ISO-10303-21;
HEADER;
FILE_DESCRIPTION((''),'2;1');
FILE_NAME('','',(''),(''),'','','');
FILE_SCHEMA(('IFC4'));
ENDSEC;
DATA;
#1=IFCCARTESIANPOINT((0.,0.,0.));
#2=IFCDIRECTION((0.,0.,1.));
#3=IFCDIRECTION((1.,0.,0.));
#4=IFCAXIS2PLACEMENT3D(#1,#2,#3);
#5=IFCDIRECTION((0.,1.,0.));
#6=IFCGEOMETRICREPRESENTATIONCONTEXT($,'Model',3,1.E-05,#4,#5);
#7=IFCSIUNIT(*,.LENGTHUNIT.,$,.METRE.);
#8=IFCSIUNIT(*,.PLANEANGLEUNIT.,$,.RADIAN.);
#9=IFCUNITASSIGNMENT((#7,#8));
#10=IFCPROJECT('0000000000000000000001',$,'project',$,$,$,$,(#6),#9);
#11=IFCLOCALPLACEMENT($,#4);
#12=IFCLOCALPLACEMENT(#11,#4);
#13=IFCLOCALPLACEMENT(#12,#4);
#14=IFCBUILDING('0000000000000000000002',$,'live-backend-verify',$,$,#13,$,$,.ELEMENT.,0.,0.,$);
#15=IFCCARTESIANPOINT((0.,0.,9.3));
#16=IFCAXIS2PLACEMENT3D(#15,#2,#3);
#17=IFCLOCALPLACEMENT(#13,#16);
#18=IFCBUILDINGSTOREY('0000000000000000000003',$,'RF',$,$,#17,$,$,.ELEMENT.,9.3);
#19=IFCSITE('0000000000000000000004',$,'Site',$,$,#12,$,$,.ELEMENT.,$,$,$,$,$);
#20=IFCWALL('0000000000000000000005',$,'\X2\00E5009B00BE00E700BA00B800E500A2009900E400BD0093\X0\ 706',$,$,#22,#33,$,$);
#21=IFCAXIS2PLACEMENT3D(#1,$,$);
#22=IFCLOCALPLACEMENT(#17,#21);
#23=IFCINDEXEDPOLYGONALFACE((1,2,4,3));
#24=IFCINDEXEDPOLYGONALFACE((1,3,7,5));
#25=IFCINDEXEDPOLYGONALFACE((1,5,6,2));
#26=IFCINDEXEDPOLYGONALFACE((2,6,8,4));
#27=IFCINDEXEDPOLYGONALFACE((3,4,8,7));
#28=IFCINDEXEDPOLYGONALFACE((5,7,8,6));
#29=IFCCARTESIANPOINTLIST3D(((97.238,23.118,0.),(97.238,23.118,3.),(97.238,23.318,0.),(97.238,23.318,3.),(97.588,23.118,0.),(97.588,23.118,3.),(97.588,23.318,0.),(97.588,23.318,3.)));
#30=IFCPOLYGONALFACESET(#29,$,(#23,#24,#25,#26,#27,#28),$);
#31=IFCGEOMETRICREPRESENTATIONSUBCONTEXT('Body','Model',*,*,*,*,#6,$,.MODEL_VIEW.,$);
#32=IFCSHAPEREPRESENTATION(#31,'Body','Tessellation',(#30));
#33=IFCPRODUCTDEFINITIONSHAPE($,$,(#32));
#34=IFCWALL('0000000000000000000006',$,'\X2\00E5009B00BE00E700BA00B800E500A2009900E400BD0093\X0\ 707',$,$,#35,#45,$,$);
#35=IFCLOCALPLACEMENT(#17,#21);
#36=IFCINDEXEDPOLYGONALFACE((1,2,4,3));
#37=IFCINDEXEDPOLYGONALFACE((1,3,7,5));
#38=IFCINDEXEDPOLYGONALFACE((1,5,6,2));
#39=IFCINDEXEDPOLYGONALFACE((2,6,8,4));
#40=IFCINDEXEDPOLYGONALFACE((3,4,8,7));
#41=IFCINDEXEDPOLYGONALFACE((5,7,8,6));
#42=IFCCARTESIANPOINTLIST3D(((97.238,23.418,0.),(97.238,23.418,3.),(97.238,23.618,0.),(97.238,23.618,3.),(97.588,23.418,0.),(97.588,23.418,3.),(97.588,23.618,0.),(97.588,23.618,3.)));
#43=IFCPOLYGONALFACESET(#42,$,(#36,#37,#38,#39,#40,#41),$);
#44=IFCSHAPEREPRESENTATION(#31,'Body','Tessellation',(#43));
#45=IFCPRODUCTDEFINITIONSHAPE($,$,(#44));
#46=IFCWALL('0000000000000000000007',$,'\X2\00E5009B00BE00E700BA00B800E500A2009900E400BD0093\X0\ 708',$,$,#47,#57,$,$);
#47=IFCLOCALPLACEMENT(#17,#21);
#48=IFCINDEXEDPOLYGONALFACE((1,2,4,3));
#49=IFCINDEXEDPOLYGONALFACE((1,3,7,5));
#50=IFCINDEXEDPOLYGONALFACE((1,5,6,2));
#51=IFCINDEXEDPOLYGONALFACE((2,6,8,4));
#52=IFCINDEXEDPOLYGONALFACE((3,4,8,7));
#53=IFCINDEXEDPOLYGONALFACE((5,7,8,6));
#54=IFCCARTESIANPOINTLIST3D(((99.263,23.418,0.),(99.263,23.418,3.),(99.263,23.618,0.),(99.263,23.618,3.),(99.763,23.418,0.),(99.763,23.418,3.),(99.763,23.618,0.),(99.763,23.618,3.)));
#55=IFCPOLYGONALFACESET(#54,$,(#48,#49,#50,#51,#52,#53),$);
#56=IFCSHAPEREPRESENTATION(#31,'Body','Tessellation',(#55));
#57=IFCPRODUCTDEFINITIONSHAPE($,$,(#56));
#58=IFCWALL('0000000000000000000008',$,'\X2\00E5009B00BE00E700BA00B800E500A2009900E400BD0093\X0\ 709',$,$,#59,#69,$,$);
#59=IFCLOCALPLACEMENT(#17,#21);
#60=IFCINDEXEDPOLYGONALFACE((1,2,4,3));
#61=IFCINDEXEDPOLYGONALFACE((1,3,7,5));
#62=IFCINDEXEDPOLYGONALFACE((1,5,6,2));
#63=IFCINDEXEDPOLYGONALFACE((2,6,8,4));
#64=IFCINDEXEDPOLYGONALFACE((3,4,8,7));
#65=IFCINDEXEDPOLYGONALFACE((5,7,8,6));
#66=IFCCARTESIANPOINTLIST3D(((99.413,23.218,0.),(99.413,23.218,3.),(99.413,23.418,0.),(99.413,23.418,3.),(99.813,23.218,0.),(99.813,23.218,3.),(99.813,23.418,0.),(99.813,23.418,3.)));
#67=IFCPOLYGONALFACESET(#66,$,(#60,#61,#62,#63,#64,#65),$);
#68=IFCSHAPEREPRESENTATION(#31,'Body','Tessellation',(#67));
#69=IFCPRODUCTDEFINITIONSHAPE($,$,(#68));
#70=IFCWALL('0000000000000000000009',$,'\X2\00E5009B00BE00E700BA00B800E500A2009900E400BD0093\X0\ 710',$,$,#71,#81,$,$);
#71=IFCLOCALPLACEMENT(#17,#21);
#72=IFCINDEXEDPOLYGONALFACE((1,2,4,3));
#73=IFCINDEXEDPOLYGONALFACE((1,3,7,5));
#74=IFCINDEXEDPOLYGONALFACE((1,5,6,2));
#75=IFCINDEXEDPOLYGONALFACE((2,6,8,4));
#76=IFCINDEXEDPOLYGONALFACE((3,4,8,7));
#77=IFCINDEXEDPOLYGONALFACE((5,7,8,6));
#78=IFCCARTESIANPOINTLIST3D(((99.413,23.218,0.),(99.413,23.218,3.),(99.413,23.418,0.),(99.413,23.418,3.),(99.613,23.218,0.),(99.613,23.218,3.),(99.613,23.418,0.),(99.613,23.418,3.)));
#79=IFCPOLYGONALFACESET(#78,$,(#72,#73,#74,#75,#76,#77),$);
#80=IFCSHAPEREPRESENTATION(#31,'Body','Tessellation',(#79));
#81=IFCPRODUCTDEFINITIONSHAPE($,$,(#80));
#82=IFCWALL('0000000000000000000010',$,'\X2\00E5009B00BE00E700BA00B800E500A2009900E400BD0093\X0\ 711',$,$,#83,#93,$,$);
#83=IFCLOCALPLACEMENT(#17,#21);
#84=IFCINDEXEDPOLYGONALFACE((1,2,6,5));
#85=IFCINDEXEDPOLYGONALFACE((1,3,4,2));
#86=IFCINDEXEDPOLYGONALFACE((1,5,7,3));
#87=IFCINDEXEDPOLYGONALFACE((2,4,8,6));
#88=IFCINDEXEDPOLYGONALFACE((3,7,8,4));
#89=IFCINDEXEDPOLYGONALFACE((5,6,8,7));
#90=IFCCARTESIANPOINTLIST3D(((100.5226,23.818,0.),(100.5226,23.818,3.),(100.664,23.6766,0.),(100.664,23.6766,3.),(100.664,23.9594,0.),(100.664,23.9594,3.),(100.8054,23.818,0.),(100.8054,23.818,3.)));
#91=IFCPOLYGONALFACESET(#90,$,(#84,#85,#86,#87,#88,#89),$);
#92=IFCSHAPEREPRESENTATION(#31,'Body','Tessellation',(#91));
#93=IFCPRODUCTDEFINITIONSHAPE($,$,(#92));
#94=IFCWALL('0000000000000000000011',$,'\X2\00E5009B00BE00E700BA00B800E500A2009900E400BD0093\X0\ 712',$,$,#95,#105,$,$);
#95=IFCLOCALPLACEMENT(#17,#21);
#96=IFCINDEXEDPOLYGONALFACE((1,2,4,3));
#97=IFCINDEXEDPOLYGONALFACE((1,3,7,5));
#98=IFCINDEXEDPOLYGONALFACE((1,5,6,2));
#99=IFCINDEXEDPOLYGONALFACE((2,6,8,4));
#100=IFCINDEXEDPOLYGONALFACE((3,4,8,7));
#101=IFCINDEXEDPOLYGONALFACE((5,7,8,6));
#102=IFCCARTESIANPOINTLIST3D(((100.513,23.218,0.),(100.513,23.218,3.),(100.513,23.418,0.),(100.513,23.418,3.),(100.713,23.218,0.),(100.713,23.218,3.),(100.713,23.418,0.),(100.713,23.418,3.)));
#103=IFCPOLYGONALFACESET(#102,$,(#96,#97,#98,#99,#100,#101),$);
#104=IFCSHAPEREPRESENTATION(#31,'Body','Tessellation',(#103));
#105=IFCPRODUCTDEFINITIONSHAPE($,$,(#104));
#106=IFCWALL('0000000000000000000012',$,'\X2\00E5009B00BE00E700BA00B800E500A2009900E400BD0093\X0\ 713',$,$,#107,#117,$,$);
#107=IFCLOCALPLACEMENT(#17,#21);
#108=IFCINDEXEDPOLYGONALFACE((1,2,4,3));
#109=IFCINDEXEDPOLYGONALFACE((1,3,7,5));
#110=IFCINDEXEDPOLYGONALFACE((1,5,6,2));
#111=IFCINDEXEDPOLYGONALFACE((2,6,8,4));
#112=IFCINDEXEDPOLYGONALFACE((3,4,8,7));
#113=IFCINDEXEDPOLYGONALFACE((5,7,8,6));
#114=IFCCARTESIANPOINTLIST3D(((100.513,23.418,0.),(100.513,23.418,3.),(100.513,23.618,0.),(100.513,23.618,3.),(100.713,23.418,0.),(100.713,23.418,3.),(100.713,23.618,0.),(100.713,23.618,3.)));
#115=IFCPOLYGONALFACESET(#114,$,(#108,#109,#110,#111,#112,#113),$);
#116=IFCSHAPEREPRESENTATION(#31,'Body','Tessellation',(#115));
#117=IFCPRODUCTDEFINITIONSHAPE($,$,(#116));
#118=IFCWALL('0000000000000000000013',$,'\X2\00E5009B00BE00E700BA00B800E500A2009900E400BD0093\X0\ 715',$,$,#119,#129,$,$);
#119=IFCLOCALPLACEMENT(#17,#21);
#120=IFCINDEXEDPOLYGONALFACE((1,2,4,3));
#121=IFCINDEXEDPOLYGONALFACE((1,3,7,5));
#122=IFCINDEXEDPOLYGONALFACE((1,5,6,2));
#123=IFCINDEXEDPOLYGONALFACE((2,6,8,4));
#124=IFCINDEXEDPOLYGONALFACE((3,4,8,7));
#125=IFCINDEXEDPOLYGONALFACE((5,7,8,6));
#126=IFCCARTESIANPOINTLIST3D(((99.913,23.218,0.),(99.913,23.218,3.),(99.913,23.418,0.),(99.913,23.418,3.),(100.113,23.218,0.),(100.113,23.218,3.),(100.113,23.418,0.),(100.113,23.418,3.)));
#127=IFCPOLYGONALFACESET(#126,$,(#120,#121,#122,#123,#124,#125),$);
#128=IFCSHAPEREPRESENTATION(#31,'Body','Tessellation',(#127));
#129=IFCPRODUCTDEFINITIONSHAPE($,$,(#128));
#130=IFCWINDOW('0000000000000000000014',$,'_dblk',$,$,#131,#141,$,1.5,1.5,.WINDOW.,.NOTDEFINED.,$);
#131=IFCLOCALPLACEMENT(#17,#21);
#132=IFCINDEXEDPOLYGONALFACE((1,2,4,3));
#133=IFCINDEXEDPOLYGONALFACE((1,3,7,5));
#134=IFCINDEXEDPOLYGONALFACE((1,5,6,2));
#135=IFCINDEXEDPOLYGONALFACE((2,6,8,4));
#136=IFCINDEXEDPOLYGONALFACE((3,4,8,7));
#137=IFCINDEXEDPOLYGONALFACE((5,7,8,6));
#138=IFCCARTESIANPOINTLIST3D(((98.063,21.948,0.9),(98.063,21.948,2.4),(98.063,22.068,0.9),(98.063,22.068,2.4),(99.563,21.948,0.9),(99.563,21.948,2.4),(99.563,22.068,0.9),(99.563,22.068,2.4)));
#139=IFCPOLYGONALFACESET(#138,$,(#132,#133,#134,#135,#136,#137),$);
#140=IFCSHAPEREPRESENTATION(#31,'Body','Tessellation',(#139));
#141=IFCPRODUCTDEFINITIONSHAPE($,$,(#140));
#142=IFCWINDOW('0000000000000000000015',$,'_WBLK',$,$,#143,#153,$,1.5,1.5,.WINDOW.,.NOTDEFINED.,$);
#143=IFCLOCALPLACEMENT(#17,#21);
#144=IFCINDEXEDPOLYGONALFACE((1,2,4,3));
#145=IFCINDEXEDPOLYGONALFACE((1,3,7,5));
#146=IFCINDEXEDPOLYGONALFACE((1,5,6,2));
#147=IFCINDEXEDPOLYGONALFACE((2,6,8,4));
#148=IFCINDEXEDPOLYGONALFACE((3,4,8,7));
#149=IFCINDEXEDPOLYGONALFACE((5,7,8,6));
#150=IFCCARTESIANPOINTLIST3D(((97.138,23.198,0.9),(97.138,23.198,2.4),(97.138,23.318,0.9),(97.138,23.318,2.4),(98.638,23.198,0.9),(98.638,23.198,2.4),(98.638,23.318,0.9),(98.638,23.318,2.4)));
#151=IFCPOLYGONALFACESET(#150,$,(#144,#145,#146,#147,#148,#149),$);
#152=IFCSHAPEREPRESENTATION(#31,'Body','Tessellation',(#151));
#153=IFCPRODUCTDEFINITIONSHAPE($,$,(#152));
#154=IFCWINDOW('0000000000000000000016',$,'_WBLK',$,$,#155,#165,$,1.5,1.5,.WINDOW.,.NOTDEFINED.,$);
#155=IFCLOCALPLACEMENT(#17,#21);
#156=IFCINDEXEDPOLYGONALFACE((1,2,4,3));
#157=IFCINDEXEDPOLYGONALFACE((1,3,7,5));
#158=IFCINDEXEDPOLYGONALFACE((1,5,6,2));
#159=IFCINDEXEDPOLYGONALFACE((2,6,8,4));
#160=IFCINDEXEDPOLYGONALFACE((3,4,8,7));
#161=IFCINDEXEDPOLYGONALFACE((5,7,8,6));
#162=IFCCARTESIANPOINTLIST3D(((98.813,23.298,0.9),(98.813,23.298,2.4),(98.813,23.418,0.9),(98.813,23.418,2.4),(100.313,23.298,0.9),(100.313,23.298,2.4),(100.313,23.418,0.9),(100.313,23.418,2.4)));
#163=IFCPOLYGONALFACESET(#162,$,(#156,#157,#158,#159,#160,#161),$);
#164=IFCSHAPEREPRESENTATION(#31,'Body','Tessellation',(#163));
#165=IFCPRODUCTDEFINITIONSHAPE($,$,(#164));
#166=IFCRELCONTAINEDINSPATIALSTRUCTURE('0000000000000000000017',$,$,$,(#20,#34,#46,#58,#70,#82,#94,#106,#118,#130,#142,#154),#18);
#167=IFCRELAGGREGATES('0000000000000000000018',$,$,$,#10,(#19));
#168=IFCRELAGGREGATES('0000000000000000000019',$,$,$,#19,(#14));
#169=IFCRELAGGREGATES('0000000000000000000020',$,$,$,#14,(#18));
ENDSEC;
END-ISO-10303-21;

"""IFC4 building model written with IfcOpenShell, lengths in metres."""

from ifc_helpers import new_model, si_unit, direction, frame, frame_2d, origin_with_axes, place, context, subcontext, project, spatial, rectangle, extrude, element, save


model = new_model("IFC4")

# Units and contexts
model_context = context("Model", 3, precision=1e-05, world=origin_with_axes(), true_north=direction((0.0, 1.0, 0.0)))
body_context = subcontext(model_context, "Body", "Model", "MODEL_VIEW")
ifc_project = project(units=[si_unit("LENGTHUNIT", "METRE"), si_unit("PLANEANGLEUNIT", "RADIAN")], contexts=[model_context])

# Site, building, storey
placement = place(None, origin_with_axes())
site_placement = place(placement, origin_with_axes())
site = spatial("IfcSite", under=ifc_project, at=site_placement, Name="Site", CompositionType="ELEMENT")
building_placement = place(site_placement, origin_with_axes())
building = spatial("IfcBuilding", under=site, at=building_placement, Name="live-backend-verify", CompositionType="ELEMENT", ElevationOfRefHeight=0.0, ElevationOfTerrain=0.0)
storey_placement = place(building_placement, frame((0.0, 0.0, 9.3), z_axis=(0.0, 0.0, 1.0), x_axis=(1.0, 0.0, 0.0)))
storey = spatial("IfcBuildingStorey", under=building, at=storey_placement, Name="RF", CompositionType="ELEMENT", Elevation=9.3)

# Walls
for number, where, z_axis, x_axis, name in (
    (1, (97.413, 23.218, 0.0), (0.0, 0.0, 1.0), (1.0, 0.0, 0.0), "å\u009b¾çº¸å¢\u0099ä½\u0093 706"),
    (2, (97.413, 23.518, 0.0), (0.0, 0.0, 1.0), (1.0, 0.0, 0.0), "å\u009b¾çº¸å¢\u0099ä½\u0093 707"),
):
    element("IfcWall", number, at=place(storey_placement, frame(where, z_axis=z_axis, x_axis=x_axis)), inside=storey, Name=name, context=body_context, shape_type="SweptSolid", body=[
        extrude(rectangle(XDim=0.35, YDim=0.2, at=frame_2d((0.0, 0.0), x_axis=(1.0, 0.0, 0.0))), frame((0.0, 0.0, 0.0), z_axis=(0.0, 0.0, 1.0)), (0.0, 0.0, 1.0), 3.0),
    ])
wall_1_placement = place(storey_placement, frame((99.513, 23.518, 0.0), z_axis=(0.0, 0.0, 1.0), x_axis=(1.0, 0.0, 0.0)))
element("IfcWall", 3, at=wall_1_placement, inside=storey, Name="å\u009b¾çº¸å¢\u0099ä½\u0093 708", context=body_context, shape_type="SweptSolid", body=[
    extrude(rectangle(XDim=0.5, YDim=0.2, at=frame_2d((0.0, 0.0), x_axis=(1.0, 0.0, 0.0))), frame((0.0, 0.0, 0.0), z_axis=(0.0, 0.0, 1.0)), (0.0, 0.0, 1.0), 3.0),
])
wall_2_placement = place(storey_placement, frame((99.613, 23.318, 0.0), z_axis=(0.0, 0.0, 1.0), x_axis=(1.0, 0.0, 0.0)))
element("IfcWall", 4, at=wall_2_placement, inside=storey, Name="å\u009b¾çº¸å¢\u0099ä½\u0093 709", context=body_context, shape_type="SweptSolid", body=[
    extrude(rectangle(XDim=0.4, YDim=0.2, at=frame_2d((0.0, 0.0), x_axis=(1.0, 0.0, 0.0))), frame((0.0, 0.0, 0.0), z_axis=(0.0, 0.0, 1.0)), (0.0, 0.0, 1.0), 3.0),
])
for number, where, z_axis, x_axis, name in (
    (5, (99.513, 23.318, 0.0), (0.0, 0.0, 1.0), (0.0, 1.0, 0.0), "å\u009b¾çº¸å¢\u0099ä½\u0093 710"),
    (6, (100.664, 23.818, 0.0), (0.0, 0.0, 1.0), (-0.707107, -0.707107, 0.0), "å\u009b¾çº¸å¢\u0099ä½\u0093 711"),
    (7, (100.613, 23.318, 0.0), (0.0, 0.0, 1.0), (1.0, 0.0, 0.0), "å\u009b¾çº¸å¢\u0099ä½\u0093 712"),
    (8, (100.613, 23.518, 0.0), (0.0, 0.0, 1.0), (1.0, 0.0, 0.0), "å\u009b¾çº¸å¢\u0099ä½\u0093 713"),
    (9, (100.013, 23.318, 0.0), (0.0, 0.0, 1.0), (0.0, 1.0, 0.0), "å\u009b¾çº¸å¢\u0099ä½\u0093 715"),
):
    element("IfcWall", number, at=place(storey_placement, frame(where, z_axis=z_axis, x_axis=x_axis)), inside=storey, Name=name, context=body_context, shape_type="SweptSolid", body=[
        extrude(rectangle(XDim=0.2, YDim=0.2, at=frame_2d((0.0, 0.0), x_axis=(1.0, 0.0, 0.0))), frame((0.0, 0.0, 0.0), z_axis=(0.0, 0.0, 1.0)), (0.0, 0.0, 1.0), 3.0),
    ])

# Windows
for number, where, z_axis, x_axis, name in (
    (10, (98.813, 22.008, 0.9), (0.0, 0.0, 1.0), (1.0, 0.0, 0.0), "_dblk"),
    (11, (97.888, 23.258, 0.9), (0.0, 0.0, 1.0), (1.0, 0.0, 0.0), "_WBLK"),
    (12, (99.563, 23.358, 0.9), (0.0, 0.0, 1.0), (1.0, 0.0, 0.0), "_WBLK"),
):
    element("IfcWindow", number, at=place(storey_placement, frame(where, z_axis=z_axis, x_axis=x_axis)), inside=storey, Name=name, OverallHeight=1.5, OverallWidth=1.5, PartitioningType="NOTDEFINED", PredefinedType="WINDOW", context=body_context, shape_type="SweptSolid", body=[
        extrude(rectangle(XDim=1.5, YDim=0.12, at=frame_2d((0.0, 0.0), x_axis=(1.0, 0.0, 0.0))), frame((0.0, 0.0, 0.0), z_axis=(0.0, 0.0, 1.0)), (0.0, 0.0, 1.0), 1.5),
    ])

save(model, "model.ifc")
